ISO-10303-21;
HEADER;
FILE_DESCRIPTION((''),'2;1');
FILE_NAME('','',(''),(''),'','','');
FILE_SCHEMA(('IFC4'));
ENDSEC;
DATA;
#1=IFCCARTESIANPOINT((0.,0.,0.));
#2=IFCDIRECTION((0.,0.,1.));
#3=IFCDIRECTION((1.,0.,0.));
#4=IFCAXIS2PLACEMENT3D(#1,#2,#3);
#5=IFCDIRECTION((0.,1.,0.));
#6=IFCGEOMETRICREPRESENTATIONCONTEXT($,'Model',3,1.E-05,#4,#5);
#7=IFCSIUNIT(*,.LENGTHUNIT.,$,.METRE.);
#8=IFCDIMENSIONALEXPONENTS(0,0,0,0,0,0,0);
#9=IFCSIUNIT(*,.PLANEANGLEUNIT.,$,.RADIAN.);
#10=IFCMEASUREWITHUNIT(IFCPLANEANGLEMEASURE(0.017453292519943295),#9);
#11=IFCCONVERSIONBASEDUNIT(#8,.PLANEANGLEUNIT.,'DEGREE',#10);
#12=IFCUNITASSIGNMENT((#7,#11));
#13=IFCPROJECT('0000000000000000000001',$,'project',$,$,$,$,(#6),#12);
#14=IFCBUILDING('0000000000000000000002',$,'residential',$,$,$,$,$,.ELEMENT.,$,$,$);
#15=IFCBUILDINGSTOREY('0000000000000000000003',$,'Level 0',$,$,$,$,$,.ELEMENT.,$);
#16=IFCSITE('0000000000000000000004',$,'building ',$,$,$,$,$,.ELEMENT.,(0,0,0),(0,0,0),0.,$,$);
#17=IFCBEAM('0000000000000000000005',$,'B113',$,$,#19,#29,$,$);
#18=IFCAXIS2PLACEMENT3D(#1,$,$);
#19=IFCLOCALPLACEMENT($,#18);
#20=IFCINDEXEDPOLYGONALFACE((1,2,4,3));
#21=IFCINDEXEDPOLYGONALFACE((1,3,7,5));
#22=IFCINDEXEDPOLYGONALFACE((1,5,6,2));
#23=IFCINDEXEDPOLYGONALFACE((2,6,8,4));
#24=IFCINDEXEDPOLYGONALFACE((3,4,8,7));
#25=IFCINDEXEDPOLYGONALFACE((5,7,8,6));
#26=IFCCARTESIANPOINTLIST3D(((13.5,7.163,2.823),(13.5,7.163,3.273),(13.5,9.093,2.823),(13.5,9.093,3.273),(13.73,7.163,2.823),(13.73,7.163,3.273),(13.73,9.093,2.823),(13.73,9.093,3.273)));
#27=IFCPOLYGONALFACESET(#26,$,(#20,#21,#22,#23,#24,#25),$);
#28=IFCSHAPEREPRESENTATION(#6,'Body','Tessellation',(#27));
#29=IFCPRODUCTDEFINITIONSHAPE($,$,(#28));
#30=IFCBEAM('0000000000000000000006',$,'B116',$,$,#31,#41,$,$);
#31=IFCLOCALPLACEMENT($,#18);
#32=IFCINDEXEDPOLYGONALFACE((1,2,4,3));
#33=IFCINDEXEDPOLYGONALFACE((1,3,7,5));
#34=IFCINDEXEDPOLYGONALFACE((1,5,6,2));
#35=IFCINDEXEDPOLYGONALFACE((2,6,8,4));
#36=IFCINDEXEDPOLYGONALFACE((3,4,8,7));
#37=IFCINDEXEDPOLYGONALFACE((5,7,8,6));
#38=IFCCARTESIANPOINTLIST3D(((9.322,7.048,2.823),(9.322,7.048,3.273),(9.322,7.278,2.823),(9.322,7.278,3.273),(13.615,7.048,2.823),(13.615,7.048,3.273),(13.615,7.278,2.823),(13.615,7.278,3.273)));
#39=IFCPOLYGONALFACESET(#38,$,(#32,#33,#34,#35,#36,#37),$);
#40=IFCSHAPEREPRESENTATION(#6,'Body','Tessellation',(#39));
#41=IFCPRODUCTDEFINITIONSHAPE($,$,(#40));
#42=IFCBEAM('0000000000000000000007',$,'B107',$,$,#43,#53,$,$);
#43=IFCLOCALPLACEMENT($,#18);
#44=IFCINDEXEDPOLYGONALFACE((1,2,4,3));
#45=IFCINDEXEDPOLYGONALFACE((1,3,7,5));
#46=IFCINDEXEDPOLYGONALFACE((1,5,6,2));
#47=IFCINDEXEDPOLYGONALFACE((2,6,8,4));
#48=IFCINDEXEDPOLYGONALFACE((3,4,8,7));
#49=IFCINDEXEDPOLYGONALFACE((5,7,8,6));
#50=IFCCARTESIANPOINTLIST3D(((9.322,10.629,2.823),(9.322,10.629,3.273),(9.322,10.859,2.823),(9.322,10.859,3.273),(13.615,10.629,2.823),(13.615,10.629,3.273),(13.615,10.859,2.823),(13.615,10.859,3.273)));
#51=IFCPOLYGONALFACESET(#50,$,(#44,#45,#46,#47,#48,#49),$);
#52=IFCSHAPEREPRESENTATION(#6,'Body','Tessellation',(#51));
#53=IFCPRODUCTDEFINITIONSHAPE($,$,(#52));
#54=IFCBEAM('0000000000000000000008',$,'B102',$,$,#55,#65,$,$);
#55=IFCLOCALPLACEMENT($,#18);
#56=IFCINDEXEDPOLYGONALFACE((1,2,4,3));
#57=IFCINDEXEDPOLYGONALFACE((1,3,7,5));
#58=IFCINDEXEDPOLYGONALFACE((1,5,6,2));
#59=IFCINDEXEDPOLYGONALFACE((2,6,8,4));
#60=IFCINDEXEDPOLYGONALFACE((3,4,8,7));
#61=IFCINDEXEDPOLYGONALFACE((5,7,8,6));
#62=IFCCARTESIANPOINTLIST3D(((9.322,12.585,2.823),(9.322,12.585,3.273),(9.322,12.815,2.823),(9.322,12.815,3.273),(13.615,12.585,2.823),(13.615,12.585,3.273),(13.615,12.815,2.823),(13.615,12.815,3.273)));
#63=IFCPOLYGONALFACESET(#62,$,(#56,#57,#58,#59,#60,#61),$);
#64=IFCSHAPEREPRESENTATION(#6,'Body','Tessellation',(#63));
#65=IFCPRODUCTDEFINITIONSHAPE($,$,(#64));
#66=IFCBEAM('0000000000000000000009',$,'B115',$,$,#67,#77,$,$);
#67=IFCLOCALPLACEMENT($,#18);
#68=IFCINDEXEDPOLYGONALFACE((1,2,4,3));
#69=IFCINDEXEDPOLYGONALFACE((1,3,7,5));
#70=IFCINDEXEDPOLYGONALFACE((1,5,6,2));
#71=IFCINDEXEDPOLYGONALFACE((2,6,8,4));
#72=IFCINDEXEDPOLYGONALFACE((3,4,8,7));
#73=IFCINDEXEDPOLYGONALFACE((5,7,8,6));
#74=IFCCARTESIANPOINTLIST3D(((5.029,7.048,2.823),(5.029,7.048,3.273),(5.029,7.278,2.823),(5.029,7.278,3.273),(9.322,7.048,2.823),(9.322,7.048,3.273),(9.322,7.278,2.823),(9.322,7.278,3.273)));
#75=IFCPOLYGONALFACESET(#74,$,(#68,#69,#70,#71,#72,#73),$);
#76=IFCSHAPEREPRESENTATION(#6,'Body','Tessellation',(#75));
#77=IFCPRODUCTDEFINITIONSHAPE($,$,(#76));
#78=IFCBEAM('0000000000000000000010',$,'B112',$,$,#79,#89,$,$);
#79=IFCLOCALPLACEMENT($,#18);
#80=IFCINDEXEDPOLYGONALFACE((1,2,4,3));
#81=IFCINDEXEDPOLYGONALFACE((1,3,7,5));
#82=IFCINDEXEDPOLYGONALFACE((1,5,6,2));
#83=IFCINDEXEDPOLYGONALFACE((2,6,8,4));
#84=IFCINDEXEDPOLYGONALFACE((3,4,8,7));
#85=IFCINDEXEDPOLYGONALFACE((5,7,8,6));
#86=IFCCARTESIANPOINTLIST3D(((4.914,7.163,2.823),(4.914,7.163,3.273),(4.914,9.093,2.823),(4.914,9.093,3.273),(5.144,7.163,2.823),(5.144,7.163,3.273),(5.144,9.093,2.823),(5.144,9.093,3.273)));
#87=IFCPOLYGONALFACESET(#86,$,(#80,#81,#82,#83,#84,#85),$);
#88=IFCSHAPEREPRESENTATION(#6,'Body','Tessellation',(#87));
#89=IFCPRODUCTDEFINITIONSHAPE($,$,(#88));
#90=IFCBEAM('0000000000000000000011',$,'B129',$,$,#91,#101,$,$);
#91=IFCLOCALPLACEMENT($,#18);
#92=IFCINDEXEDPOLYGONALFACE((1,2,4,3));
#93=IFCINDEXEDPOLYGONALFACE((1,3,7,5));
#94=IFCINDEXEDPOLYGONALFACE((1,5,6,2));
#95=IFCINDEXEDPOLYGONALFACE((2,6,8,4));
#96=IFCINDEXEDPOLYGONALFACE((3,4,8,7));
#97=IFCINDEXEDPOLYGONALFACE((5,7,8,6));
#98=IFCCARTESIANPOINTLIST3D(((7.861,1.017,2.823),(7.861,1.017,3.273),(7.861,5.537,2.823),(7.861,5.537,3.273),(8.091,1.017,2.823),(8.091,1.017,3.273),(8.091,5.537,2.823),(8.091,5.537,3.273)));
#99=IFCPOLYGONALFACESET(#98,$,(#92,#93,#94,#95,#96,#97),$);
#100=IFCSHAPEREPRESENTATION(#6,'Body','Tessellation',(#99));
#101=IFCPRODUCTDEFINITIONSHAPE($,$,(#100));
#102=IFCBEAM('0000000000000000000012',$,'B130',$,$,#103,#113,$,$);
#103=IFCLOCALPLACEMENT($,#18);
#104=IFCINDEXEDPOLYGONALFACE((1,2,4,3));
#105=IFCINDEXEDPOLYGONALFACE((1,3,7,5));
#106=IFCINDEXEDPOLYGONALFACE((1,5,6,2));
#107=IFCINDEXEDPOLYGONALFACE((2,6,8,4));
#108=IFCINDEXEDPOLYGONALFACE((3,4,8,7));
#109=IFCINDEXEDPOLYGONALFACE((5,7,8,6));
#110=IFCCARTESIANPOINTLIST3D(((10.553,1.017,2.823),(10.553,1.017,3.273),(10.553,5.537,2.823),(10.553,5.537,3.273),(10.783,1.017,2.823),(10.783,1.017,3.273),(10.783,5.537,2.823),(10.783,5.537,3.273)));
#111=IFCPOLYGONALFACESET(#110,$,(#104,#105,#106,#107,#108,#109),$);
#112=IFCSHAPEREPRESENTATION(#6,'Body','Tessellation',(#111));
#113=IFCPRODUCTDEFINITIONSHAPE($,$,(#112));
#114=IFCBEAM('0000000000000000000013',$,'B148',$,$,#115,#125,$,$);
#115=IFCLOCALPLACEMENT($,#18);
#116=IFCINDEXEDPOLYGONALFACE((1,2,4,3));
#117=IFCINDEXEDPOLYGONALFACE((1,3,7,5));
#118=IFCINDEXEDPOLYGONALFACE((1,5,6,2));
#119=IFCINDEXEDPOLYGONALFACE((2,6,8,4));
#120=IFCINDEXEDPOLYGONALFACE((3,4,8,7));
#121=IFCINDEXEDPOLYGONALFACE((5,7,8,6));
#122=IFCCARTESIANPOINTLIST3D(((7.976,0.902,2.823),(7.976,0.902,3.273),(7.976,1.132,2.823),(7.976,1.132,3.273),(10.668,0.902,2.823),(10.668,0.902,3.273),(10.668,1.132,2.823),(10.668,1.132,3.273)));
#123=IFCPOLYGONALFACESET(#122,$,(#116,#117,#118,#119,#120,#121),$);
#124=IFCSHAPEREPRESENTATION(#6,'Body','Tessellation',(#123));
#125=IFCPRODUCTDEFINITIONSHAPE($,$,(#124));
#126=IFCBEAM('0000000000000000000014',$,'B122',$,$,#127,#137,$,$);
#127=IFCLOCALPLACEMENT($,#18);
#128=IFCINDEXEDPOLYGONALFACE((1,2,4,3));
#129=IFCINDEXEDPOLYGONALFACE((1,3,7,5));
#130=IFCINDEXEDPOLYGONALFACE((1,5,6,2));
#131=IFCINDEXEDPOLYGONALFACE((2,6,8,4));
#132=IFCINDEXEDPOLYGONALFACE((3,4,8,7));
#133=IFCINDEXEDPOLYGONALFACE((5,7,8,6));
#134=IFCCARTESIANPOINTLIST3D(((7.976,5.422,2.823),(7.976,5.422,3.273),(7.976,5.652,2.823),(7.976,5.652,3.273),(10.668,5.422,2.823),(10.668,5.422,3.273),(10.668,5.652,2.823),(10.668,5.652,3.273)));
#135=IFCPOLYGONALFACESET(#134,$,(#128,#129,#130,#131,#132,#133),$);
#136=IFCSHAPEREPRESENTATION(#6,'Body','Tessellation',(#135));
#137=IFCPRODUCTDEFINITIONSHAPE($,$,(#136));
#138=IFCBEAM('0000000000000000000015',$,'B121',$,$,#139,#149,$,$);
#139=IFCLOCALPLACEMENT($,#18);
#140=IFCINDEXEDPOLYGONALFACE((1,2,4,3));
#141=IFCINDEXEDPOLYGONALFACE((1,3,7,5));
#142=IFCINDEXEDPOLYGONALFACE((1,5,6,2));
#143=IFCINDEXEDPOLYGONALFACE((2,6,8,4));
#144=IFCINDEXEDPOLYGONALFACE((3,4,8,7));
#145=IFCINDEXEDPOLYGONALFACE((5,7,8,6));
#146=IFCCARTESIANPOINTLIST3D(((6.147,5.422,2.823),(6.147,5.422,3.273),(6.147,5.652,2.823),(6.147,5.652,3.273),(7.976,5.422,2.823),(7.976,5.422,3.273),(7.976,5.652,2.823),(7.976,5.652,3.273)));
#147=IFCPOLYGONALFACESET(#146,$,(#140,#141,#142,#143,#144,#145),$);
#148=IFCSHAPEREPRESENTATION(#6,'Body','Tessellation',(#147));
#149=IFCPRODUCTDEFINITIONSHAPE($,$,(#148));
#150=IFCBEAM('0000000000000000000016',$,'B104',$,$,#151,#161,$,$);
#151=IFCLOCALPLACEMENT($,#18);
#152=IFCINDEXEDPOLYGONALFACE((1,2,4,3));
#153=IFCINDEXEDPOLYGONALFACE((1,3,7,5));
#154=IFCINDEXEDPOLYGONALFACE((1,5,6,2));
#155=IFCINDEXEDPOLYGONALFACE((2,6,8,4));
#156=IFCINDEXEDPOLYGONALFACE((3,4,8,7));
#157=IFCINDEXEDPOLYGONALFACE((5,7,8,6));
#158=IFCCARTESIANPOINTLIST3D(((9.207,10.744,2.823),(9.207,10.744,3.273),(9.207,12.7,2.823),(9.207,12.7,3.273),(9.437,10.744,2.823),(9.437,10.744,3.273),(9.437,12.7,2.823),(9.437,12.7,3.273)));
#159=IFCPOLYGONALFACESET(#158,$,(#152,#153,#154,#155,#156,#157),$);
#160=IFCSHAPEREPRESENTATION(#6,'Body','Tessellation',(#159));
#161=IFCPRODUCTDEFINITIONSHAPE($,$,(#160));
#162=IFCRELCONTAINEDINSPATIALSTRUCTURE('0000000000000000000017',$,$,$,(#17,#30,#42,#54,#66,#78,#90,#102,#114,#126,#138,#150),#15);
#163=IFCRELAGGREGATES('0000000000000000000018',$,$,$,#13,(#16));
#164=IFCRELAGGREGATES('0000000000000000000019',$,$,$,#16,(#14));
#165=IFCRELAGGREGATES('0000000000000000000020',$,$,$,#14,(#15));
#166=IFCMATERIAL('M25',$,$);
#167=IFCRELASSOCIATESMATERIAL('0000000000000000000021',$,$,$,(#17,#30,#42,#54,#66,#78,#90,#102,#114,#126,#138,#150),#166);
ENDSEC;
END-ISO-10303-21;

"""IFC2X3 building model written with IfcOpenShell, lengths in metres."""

from ifc_helpers import new_model, entity, si_unit, converted_unit, direction, frame, frame_2d, origin_with_axes, place, context, project, spatial, rectangle, extrude, material, element, save


model = new_model("IFC2X3")

# Units and contexts
model_context = context("Model", 3, precision=1e-05, world=origin_with_axes(), true_north=direction((0.0, 1.0, 0.0)))
ifc_project = project(units=[si_unit("LENGTHUNIT", "METRE"), converted_unit("PLANEANGLEUNIT", "DEGREE", entity("IfcPlaneAngleMeasure", 0.017453292519943295), si_unit("PLANEANGLEUNIT", "RADIAN"), dimensions=[0, 0, 0, 0, 0, 0, 0])], contexts=[model_context])

# Site, building, storey
site = spatial("IfcSite", under=ifc_project, Name="building ", CompositionType="ELEMENT", RefLatitude=(0, 0, 0), RefLongitude=(0, 0, 0), RefElevation=0.0)
building = spatial("IfcBuilding", under=site, Name="residential", CompositionType="ELEMENT")
storey = spatial("IfcBuildingStorey", under=building, Name="Level 0", CompositionType="ELEMENT")

# Beams
ifc_material = material(Name="M25")
placement = place(None, origin_with_axes())
element("IfcBeam", 1, at=placement, inside=storey, material=ifc_material, Name="B113", context=model_context, shape_type="SweptSolid", body=[
    extrude(rectangle(XDim=0.23, YDim=0.45, at=frame_2d((0.0, 0.0), x_axis=(0.0, 1.0, 0.0))), frame((13.615, 7.163, 3.048), z_axis=(0.0, 1.0, 0.0), x_axis=(0.0, 0.0, -1.0)), (0.0, 0.0, 1.0), 1.93),
])
element("IfcBeam", 2, at=placement, inside=storey, material=ifc_material, Name="B116", context=model_context, shape_type="SweptSolid", body=[
    extrude(rectangle(XDim=0.23, YDim=0.45, at=frame_2d((0.0, 0.0), x_axis=(0.0, 1.0, 0.0))), frame((9.322, 7.163, 3.048), z_axis=(1.0, 0.0, 0.0), x_axis=(0.0, 0.0, -1.0)), (0.0, 0.0, 1.0), 4.293),
])
element("IfcBeam", 3, at=placement, inside=storey, material=ifc_material, Name="B107", context=model_context, shape_type="SweptSolid", body=[
    extrude(rectangle(XDim=0.23, YDim=0.45, at=frame_2d((0.0, 0.0), x_axis=(0.0, 1.0, 0.0))), frame((9.322, 10.744, 3.048), z_axis=(1.0, 0.0, 0.0), x_axis=(0.0, 0.0, -1.0)), (0.0, 0.0, 1.0), 4.293),
])
element("IfcBeam", 4, at=placement, inside=storey, material=ifc_material, Name="B102", context=model_context, shape_type="SweptSolid", body=[
    extrude(rectangle(XDim=0.23, YDim=0.45, at=frame_2d((0.0, 0.0), x_axis=(0.0, 1.0, 0.0))), frame((9.322, 12.7, 3.048), z_axis=(1.0, 0.0, 0.0), x_axis=(0.0, 0.0, -1.0)), (0.0, 0.0, 1.0), 4.293),
])
element("IfcBeam", 5, at=placement, inside=storey, material=ifc_material, Name="B115", context=model_context, shape_type="SweptSolid", body=[
    extrude(rectangle(XDim=0.23, YDim=0.45, at=frame_2d((0.0, 0.0), x_axis=(0.0, 1.0, 0.0))), frame((5.029, 7.163, 3.048), z_axis=(1.0, 0.0, 0.0), x_axis=(0.0, 0.0, -1.0)), (0.0, 0.0, 1.0), 4.293),
])
element("IfcBeam", 6, at=placement, inside=storey, material=ifc_material, Name="B112", context=model_context, shape_type="SweptSolid", body=[
    extrude(rectangle(XDim=0.23, YDim=0.45, at=frame_2d((0.0, 0.0), x_axis=(0.0, 1.0, 0.0))), frame((5.029, 9.093, 3.048), z_axis=(0.0, -1.0, 0.0), x_axis=(0.0, 0.0, -1.0)), (0.0, 0.0, 1.0), 1.93),
])
element("IfcBeam", 7, at=placement, inside=storey, material=ifc_material, Name="B129", context=model_context, shape_type="SweptSolid", body=[
    extrude(rectangle(XDim=0.23, YDim=0.45, at=frame_2d((0.0, 0.0), x_axis=(0.0, 1.0, 0.0))), frame((7.976, 1.017, 3.048), z_axis=(0.0, 1.0, 0.0), x_axis=(0.0, 0.0, -1.0)), (0.0, 0.0, 1.0), 4.52),
])
element("IfcBeam", 8, at=placement, inside=storey, material=ifc_material, Name="B130", context=model_context, shape_type="SweptSolid", body=[
    extrude(rectangle(XDim=0.23, YDim=0.45, at=frame_2d((0.0, 0.0), x_axis=(0.0, 1.0, 0.0))), frame((10.668, 1.017, 3.048), z_axis=(0.0, 1.0, 0.0), x_axis=(0.0, 0.0, -1.0)), (0.0, 0.0, 1.0), 4.52),
])
element("IfcBeam", 9, at=placement, inside=storey, material=ifc_material, Name="B148", context=model_context, shape_type="SweptSolid", body=[
    extrude(rectangle(XDim=0.23, YDim=0.45, at=frame_2d((0.0, 0.0), x_axis=(0.0, 1.0, 0.0))), frame((7.976, 1.017, 3.048), z_axis=(1.0, 0.0, 0.0), x_axis=(0.0, 0.0, -1.0)), (0.0, 0.0, 1.0), 2.692),
])
element("IfcBeam", 10, at=placement, inside=storey, material=ifc_material, Name="B122", context=model_context, shape_type="SweptSolid", body=[
    extrude(rectangle(XDim=0.23, YDim=0.45, at=frame_2d((0.0, 0.0), x_axis=(0.0, 1.0, 0.0))), frame((7.976, 5.537, 3.048), z_axis=(1.0, 0.0, 0.0), x_axis=(0.0, 0.0, -1.0)), (0.0, 0.0, 1.0), 2.692),
])
element("IfcBeam", 11, at=placement, inside=storey, material=ifc_material, Name="B121", context=model_context, shape_type="SweptSolid", body=[
    extrude(rectangle(XDim=0.23, YDim=0.45, at=frame_2d((0.0, 0.0), x_axis=(0.0, 1.0, 0.0))), frame((6.147, 5.537, 3.048), z_axis=(1.0, 0.0, 0.0), x_axis=(0.0, 0.0, -1.0)), (0.0, 0.0, 1.0), 1.829),
])
element("IfcBeam", 12, at=placement, inside=storey, material=ifc_material, Name="B104", context=model_context, shape_type="SweptSolid", body=[
    extrude(rectangle(XDim=0.23, YDim=0.45, at=frame_2d((0.0, 0.0), x_axis=(0.0, 1.0, 0.0))), frame((9.322, 10.744, 3.048), z_axis=(0.0, 1.0, 0.0), x_axis=(0.0, 0.0, -1.0)), (0.0, 0.0, 1.0), 1.956),
])

save(model, "model.ifc")
